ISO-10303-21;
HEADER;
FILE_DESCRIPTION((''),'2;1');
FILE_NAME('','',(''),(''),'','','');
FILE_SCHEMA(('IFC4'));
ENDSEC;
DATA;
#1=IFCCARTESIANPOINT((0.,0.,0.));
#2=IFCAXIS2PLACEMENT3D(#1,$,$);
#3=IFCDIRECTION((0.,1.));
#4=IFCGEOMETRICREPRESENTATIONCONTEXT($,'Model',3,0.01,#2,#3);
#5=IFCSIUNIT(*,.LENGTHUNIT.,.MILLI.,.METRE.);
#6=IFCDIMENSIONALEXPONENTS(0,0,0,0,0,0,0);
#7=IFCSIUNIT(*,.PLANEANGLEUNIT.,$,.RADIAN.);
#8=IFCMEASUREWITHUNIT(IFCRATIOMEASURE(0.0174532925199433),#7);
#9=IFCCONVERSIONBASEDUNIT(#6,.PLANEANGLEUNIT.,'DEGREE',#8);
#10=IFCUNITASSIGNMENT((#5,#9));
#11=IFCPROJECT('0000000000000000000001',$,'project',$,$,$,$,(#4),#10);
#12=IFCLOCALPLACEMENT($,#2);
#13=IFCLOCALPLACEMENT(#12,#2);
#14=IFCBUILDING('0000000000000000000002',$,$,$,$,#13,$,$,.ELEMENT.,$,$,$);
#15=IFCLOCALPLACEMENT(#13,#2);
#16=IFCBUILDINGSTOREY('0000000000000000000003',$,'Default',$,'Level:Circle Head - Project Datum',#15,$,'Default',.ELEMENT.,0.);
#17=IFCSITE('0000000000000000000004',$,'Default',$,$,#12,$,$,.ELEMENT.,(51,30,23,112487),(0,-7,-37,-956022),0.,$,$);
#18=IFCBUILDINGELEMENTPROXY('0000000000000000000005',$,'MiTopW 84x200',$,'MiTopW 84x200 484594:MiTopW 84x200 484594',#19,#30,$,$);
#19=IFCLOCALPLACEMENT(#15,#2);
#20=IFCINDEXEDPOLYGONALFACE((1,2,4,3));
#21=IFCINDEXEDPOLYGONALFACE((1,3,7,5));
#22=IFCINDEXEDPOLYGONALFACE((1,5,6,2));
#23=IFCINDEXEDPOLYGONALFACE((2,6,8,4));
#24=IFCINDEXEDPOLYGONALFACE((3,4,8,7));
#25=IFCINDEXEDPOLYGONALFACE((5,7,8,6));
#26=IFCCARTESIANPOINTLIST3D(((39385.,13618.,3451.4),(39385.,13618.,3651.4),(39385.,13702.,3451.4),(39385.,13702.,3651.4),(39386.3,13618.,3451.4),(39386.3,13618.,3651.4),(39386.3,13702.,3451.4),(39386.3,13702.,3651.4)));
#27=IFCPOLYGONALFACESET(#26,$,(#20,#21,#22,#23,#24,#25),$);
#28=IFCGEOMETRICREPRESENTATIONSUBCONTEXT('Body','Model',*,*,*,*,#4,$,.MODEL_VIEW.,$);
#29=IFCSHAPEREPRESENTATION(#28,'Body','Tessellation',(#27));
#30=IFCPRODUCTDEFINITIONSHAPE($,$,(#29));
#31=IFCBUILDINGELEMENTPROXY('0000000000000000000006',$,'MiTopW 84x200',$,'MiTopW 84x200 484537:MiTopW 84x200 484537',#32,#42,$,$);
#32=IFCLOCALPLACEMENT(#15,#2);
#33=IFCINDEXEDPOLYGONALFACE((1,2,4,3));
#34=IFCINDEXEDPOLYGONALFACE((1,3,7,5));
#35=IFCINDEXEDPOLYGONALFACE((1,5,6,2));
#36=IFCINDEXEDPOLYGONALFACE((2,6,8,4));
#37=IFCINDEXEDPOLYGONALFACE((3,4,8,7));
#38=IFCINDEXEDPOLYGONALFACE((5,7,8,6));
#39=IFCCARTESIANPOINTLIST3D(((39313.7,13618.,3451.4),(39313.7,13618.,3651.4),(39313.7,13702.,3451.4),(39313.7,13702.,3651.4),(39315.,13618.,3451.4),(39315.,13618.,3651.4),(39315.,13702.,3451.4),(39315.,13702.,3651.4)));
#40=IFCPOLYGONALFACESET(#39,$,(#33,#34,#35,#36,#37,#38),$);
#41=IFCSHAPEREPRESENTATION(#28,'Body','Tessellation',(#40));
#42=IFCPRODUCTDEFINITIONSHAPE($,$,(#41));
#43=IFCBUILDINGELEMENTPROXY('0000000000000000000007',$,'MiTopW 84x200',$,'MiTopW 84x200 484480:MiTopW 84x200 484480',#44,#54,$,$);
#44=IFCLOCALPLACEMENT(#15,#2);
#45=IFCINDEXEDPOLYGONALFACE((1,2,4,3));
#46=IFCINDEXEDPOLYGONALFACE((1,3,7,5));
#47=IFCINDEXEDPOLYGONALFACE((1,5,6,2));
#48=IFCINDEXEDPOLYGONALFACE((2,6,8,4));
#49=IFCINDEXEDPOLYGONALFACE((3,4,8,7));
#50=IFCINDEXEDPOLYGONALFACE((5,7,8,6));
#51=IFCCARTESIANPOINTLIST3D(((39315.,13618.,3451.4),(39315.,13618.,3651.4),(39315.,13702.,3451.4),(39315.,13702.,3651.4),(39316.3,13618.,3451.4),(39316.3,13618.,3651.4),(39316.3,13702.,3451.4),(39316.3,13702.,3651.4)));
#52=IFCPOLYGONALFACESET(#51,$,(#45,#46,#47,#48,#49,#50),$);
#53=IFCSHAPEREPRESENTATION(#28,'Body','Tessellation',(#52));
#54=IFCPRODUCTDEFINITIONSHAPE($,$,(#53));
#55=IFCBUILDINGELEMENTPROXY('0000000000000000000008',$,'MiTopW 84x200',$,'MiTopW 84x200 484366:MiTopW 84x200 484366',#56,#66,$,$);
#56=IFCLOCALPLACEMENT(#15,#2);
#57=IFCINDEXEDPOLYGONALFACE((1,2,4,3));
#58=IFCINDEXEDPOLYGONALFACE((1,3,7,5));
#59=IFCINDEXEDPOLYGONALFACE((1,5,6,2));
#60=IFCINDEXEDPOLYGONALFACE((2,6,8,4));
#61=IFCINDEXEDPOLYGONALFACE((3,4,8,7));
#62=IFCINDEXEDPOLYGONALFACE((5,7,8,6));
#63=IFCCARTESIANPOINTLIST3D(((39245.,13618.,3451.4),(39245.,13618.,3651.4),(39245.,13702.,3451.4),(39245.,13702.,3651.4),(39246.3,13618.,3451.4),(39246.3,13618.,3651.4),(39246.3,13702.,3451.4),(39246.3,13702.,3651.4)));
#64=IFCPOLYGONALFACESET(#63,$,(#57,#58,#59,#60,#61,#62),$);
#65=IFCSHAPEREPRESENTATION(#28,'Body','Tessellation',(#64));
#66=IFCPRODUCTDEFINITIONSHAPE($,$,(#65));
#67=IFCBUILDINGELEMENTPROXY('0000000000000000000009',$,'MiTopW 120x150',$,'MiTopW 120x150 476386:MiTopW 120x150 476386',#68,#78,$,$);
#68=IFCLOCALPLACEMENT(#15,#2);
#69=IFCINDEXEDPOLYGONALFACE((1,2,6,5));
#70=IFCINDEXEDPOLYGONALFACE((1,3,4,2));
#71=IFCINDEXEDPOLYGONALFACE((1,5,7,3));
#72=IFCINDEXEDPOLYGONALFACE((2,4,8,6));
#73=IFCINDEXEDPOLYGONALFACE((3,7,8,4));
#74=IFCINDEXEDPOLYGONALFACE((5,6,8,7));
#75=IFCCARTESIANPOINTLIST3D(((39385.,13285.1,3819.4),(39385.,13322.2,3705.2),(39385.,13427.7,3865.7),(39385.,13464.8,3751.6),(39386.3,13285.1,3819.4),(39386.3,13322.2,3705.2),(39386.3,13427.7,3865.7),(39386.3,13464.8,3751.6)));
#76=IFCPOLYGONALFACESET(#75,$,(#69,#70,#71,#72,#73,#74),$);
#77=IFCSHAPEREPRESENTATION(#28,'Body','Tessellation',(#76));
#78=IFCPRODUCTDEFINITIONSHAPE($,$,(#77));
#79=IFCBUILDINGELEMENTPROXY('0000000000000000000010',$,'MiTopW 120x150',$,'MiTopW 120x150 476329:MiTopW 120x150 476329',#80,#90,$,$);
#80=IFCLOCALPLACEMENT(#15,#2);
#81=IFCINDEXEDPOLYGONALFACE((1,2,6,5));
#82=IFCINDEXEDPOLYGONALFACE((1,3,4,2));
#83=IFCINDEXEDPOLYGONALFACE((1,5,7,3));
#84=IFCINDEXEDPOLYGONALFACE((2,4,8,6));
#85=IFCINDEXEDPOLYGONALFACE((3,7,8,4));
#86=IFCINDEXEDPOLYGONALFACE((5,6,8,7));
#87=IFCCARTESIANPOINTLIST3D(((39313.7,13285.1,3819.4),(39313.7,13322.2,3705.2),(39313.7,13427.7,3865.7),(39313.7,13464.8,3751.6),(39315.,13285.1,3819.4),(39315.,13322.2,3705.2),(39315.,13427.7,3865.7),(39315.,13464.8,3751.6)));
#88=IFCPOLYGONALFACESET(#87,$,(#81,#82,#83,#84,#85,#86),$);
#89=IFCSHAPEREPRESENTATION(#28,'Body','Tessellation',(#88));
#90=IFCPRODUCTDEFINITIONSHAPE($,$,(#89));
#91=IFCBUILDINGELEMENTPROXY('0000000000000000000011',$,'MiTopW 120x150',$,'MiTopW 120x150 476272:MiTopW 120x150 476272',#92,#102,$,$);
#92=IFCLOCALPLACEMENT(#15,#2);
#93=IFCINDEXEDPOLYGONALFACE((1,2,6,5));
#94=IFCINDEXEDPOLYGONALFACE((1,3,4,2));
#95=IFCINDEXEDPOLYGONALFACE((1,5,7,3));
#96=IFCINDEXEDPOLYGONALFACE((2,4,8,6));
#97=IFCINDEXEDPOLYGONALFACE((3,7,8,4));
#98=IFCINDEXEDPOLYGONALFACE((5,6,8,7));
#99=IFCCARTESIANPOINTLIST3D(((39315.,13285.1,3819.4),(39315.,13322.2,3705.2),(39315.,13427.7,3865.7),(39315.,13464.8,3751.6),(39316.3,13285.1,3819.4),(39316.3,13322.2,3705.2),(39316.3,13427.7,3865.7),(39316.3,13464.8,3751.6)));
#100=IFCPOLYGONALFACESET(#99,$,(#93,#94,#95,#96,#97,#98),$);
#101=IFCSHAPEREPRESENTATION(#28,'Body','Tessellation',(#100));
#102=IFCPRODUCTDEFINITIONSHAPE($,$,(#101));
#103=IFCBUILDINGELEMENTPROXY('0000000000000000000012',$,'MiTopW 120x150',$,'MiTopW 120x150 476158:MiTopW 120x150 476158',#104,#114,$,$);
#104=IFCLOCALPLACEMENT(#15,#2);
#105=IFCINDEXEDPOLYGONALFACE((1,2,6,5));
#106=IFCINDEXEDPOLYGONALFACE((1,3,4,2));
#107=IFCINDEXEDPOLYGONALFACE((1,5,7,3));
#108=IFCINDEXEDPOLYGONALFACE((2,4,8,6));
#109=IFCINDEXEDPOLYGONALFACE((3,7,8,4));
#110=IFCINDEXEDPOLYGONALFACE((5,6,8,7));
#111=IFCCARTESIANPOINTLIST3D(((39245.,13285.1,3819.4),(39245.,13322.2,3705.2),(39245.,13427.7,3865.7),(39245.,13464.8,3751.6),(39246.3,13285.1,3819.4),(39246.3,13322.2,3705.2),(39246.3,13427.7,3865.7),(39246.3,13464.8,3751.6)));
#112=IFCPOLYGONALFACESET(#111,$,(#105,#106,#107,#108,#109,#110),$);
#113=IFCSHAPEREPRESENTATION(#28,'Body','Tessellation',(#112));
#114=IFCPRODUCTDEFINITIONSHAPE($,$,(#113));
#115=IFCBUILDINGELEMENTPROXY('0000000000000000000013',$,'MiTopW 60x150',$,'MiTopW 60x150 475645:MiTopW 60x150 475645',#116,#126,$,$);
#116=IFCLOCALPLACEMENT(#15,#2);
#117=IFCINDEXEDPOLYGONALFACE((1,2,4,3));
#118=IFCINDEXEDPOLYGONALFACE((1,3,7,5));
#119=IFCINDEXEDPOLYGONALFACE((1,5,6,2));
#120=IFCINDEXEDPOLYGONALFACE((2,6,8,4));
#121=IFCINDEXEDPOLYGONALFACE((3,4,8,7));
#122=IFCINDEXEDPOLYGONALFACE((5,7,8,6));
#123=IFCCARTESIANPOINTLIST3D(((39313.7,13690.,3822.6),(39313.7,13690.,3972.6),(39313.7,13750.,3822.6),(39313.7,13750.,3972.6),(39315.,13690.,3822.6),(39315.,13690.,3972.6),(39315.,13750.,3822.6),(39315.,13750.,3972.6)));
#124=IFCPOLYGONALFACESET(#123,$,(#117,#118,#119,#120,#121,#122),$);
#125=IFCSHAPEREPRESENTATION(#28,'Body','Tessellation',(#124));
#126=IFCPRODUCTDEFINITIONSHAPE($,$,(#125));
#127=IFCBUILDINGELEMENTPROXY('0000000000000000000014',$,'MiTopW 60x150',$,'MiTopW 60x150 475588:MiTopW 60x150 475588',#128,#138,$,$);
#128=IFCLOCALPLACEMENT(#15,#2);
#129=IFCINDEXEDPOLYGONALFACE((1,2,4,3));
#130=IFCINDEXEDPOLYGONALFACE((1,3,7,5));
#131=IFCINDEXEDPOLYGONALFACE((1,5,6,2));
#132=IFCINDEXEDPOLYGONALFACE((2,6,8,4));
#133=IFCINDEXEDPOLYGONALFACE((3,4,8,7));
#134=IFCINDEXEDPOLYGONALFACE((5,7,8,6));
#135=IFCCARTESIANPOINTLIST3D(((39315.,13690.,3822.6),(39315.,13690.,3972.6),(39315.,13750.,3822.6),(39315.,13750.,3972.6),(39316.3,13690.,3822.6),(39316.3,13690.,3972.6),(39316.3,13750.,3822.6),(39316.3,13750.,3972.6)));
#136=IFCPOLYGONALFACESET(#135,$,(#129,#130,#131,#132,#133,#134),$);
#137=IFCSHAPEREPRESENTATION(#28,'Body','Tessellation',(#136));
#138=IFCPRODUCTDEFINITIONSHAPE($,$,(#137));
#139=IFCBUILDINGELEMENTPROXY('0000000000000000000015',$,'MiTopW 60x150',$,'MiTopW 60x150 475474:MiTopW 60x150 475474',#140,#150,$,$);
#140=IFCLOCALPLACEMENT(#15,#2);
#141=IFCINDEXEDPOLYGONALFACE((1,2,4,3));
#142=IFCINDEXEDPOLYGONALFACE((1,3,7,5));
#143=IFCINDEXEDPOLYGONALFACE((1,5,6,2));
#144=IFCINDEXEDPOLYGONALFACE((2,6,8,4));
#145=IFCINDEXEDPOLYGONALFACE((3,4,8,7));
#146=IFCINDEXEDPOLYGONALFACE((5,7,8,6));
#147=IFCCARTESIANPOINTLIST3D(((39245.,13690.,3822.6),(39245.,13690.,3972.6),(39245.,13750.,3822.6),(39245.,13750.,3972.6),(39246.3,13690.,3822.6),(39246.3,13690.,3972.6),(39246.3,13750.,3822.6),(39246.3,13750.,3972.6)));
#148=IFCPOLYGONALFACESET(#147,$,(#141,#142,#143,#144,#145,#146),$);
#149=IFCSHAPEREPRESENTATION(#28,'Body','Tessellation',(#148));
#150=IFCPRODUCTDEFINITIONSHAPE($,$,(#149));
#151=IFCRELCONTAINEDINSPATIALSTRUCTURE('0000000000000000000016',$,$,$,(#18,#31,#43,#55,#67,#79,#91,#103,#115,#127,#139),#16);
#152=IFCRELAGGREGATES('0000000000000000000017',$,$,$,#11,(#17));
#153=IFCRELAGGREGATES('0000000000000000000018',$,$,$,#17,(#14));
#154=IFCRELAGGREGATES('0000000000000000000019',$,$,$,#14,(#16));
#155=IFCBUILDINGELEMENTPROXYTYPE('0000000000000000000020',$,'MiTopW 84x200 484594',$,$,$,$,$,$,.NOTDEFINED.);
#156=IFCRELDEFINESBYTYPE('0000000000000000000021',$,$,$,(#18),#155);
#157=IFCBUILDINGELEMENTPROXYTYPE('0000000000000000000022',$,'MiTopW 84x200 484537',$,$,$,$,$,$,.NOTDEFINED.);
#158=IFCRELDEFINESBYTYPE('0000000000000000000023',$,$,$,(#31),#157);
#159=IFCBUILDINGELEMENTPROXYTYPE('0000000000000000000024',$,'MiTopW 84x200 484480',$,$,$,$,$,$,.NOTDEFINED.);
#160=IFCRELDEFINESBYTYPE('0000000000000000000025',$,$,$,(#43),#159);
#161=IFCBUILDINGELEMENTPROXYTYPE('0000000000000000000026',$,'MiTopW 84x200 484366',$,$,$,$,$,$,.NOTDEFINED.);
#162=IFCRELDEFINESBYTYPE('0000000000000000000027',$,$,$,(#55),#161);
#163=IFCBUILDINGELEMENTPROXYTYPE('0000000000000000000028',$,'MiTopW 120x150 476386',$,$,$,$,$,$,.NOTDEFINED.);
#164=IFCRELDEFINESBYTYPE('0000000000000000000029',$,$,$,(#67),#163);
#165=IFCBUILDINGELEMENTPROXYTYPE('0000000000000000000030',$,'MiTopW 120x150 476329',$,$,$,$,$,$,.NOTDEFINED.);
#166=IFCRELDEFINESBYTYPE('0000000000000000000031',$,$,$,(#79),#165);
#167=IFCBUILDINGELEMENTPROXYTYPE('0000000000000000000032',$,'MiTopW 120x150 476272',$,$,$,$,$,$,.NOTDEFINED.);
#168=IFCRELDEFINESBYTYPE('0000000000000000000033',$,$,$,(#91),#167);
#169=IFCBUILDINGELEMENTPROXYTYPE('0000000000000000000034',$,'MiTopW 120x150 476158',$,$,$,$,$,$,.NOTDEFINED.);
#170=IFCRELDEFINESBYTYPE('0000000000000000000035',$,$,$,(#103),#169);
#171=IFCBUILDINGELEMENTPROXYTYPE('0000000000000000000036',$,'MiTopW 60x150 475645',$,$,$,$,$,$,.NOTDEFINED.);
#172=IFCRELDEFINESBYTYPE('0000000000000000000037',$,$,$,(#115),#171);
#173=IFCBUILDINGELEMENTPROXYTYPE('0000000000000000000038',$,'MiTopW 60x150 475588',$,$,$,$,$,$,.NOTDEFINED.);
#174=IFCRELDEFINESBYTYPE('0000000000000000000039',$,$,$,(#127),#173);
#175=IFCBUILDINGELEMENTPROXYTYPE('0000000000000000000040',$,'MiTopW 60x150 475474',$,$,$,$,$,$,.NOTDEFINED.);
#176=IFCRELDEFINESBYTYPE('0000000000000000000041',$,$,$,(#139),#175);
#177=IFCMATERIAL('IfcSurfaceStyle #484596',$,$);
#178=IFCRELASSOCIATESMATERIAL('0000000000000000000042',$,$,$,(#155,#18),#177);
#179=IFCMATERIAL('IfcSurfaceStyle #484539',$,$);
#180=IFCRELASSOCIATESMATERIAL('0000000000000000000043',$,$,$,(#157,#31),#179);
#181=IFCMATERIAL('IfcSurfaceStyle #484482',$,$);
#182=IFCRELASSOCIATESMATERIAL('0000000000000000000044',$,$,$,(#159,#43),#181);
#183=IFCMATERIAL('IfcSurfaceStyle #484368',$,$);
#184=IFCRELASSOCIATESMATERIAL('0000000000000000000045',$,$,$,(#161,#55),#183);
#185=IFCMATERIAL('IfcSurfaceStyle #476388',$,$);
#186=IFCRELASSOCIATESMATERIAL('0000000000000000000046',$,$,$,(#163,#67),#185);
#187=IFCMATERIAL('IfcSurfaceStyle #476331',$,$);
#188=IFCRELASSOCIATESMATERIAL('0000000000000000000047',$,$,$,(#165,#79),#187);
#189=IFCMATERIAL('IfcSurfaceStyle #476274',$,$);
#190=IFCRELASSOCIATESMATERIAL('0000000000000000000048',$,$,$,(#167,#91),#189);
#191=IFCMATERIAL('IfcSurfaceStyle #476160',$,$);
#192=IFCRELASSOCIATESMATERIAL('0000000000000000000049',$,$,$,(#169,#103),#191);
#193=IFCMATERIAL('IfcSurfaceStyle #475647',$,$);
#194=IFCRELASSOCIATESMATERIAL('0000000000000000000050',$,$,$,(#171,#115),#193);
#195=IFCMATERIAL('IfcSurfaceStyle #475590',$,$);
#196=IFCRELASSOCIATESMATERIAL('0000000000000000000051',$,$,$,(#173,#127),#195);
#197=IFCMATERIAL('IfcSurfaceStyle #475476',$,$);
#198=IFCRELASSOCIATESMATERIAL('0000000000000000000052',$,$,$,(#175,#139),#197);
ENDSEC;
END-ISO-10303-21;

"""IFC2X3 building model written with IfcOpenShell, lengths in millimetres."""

from ifc_helpers import new_model, entity, si_unit, converted_unit, direction, frame, frame_2d, origin, origin_2d_with_axis, place, context, subcontext, project, spatial, polyline, rectangle, outline, extrude, source, transform, mapped, material, type_object, type_shapes, element, save


model = new_model("IFC2X3")

# Units and contexts
model_context = context("Model", 3, precision=0.01, world=origin(), true_north=direction((0.0, 1.0)))
body_context = subcontext(model_context, "Body", "Model", "MODEL_VIEW")
ifc_project = project(units=[si_unit("LENGTHUNIT", "METRE", prefix="MILLI"), converted_unit("PLANEANGLEUNIT", "DEGREE", entity("IfcRatioMeasure", 0.0174532925199433), si_unit("PLANEANGLEUNIT", "RADIAN"), dimensions=[0, 0, 0, 0, 0, 0, 0])], contexts=[model_context])

# Site, building, storey
site_placement = place(None, origin())
site = spatial("IfcSite", under=ifc_project, at=site_placement, Name="Default", CompositionType="ELEMENT", RefLatitude=(51, 30, 23, 112487), RefLongitude=(0, -7, -37, -956022), RefElevation=0.0)
building_placement = place(site_placement, origin())
building = spatial("IfcBuilding", under=site, at=building_placement, CompositionType="ELEMENT")
storey_placement = place(building_placement, origin())
storey = spatial("IfcBuildingStorey", under=building, at=storey_placement, Name="Default", ObjectType="Level:Circle Head - Project Datum", LongName="Default", CompositionType="ELEMENT", Elevation=0.0)

# Building element proxies
ifc_material_1 = material(Name="IfcSurfaceStyle #484596")
building_element_proxy_type_1 = type_object("IfcBuildingElementProxyType", Name="MiTopW 84x200 484594", PredefinedType="NOTDEFINED", material=ifc_material_1)
shared_shape_1 = source(origin(), body_context, "Body", "SweptSolid", [
    extrude(rectangle(XDim=200.0, YDim=84.0, at=frame_2d((0.0, 0.0), x_axis=(1.0, 0.0))), frame((100.0, 42.0, 0.0), z_axis=(0.0, 0.0, 1.0), x_axis=(-1.0, 0.0, 0.0)), (0.0, 0.0, 1.0), 1.3),
])
type_shapes(building_element_proxy_type_1, [shared_shape_1])
proxy_1_placement = place(building_placement, frame((39386.3, 13702.0, 3651.4), z_axis=(-1.0, 0.0, 0.0), x_axis=(0.0, 0.0, -1.0)))
element("IfcBuildingElementProxy", 1, at=proxy_1_placement, inside=storey, type_object=building_element_proxy_type_1, material=ifc_material_1, Name="MiTopW 84x200", ObjectType="MiTopW 84x200 484594:MiTopW 84x200 484594", context=body_context, shape_type="MappedRepresentation", body=[
    mapped(shared_shape_1, transform((0.0, 0.0, 0.0), scale=1.0)),
])
ifc_material_2 = material(Name="IfcSurfaceStyle #484539")
building_element_proxy_type_2 = type_object("IfcBuildingElementProxyType", Name="MiTopW 84x200 484537", PredefinedType="NOTDEFINED", material=ifc_material_2)
shared_shape_2 = source(origin(), body_context, "Body", "SweptSolid", [
    extrude(rectangle(XDim=200.0, YDim=84.0, at=frame_2d((0.0, 0.0), x_axis=(1.0, 0.0))), frame((100.0, 42.0, 0.0), z_axis=(0.0, 0.0, 1.0), x_axis=(-1.0, 0.0, 0.0)), (0.0, 0.0, 1.0), 1.3),
])
type_shapes(building_element_proxy_type_2, [shared_shape_2])
proxy_2_placement = place(building_placement, frame((39315.0, 13702.0, 3651.4), z_axis=(-1.0, 0.0, 0.0), x_axis=(0.0, 0.0, -1.0)))
element("IfcBuildingElementProxy", 2, at=proxy_2_placement, inside=storey, type_object=building_element_proxy_type_2, material=ifc_material_2, Name="MiTopW 84x200", ObjectType="MiTopW 84x200 484537:MiTopW 84x200 484537", context=body_context, shape_type="MappedRepresentation", body=[
    mapped(shared_shape_2, transform((0.0, 0.0, 0.0), scale=1.0)),
])
ifc_material_3 = material(Name="IfcSurfaceStyle #484482")
building_element_proxy_type_3 = type_object("IfcBuildingElementProxyType", Name="MiTopW 84x200 484480", PredefinedType="NOTDEFINED", material=ifc_material_3)
shared_shape_3 = source(origin(), body_context, "Body", "SweptSolid", [
    extrude(rectangle(XDim=200.0, YDim=84.0, at=frame_2d((0.0, 0.0), x_axis=(1.0, 0.0))), frame((100.0, 42.0, 0.0), z_axis=(0.0, 0.0, 1.0), x_axis=(-1.0, 0.0, 0.0)), (0.0, 0.0, 1.0), 1.3),
])
type_shapes(building_element_proxy_type_3, [shared_shape_3])
proxy_3_placement = place(building_placement, frame((39316.3, 13702.0, 3651.4), z_axis=(-1.0, 0.0, 0.0), x_axis=(0.0, 0.0, -1.0)))
element("IfcBuildingElementProxy", 3, at=proxy_3_placement, inside=storey, type_object=building_element_proxy_type_3, material=ifc_material_3, Name="MiTopW 84x200", ObjectType="MiTopW 84x200 484480:MiTopW 84x200 484480", context=body_context, shape_type="MappedRepresentation", body=[
    mapped(shared_shape_3, transform((0.0, 0.0, 0.0), scale=1.0)),
])
ifc_material_4 = material(Name="IfcSurfaceStyle #484368")
building_element_proxy_type_4 = type_object("IfcBuildingElementProxyType", Name="MiTopW 84x200 484366", PredefinedType="NOTDEFINED", material=ifc_material_4)
shared_shape_4 = source(origin(), body_context, "Body", "SweptSolid", [
    extrude(rectangle(XDim=200.0, YDim=84.0, at=frame_2d((0.0, 0.0), x_axis=(1.0, 0.0))), frame((100.0, 42.0, 0.0), z_axis=(0.0, 0.0, 1.0), x_axis=(-1.0, 0.0, 0.0)), (0.0, 0.0, 1.0), 1.3),
])
type_shapes(building_element_proxy_type_4, [shared_shape_4])
proxy_4_placement = place(building_placement, frame((39246.3, 13702.0, 3651.4), z_axis=(-1.0, 0.0, 0.0), x_axis=(0.0, 0.0, -1.0)))
element("IfcBuildingElementProxy", 4, at=proxy_4_placement, inside=storey, type_object=building_element_proxy_type_4, material=ifc_material_4, Name="MiTopW 84x200", ObjectType="MiTopW 84x200 484366:MiTopW 84x200 484366", context=body_context, shape_type="MappedRepresentation", body=[
    mapped(shared_shape_4, transform((0.0, 0.0, 0.0), scale=1.0)),
])
ifc_material_5 = material(Name="IfcSurfaceStyle #476388")
building_element_proxy_type_5 = type_object("IfcBuildingElementProxyType", Name="MiTopW 120x150 476386", PredefinedType="NOTDEFINED", material=ifc_material_5)
shared_shape_5 = source(origin(), body_context, "Body", "SweptSolid", [
    extrude(outline(polyline([(-75.0, -60.0), (75.0, -60.0), (75.0, 60.0), (-75.0, 60.0), (-75.0, -60.0)])), frame((75.0, 60.0, 0.0), z_axis=(0.0, 0.0, 1.0), x_axis=(-1.0, 0.0, 0.0)), (0.0, 0.0, 1.0), 1.3),
])
type_shapes(building_element_proxy_type_5, [shared_shape_5])
proxy_5_placement = place(building_placement, frame((39386.3, 13285.1, 3819.4), z_axis=(-1.0, 0.0, 0.0), x_axis=(0.0, 0.951057, 0.309017)))
element("IfcBuildingElementProxy", 5, at=proxy_5_placement, inside=storey, type_object=building_element_proxy_type_5, material=ifc_material_5, Name="MiTopW 120x150", ObjectType="MiTopW 120x150 476386:MiTopW 120x150 476386", context=body_context, shape_type="MappedRepresentation", body=[
    mapped(shared_shape_5, transform((0.0, 0.0, 0.0), scale=1.0)),
])
ifc_material_6 = material(Name="IfcSurfaceStyle #476331")
building_element_proxy_type_6 = type_object("IfcBuildingElementProxyType", Name="MiTopW 120x150 476329", PredefinedType="NOTDEFINED", material=ifc_material_6)
shared_shape_6 = source(origin(), body_context, "Body", "SweptSolid", [
    extrude(outline(polyline([(-75.0, -60.0), (75.0, -60.0), (75.0, 60.0), (-75.0, 60.0), (-75.0, -60.0)])), frame((75.0, 60.0, 0.0), z_axis=(0.0, 0.0, 1.0), x_axis=(-1.0, 0.0, 0.0)), (0.0, 0.0, 1.0), 1.3),
])
type_shapes(building_element_proxy_type_6, [shared_shape_6])
proxy_6_placement = place(building_placement, frame((39315.0, 13285.1, 3819.4), z_axis=(-1.0, 0.0, 0.0), x_axis=(0.0, 0.951057, 0.309017)))
element("IfcBuildingElementProxy", 6, at=proxy_6_placement, inside=storey, type_object=building_element_proxy_type_6, material=ifc_material_6, Name="MiTopW 120x150", ObjectType="MiTopW 120x150 476329:MiTopW 120x150 476329", context=body_context, shape_type="MappedRepresentation", body=[
    mapped(shared_shape_6, transform((0.0, 0.0, 0.0), scale=1.0)),
])
ifc_material_7 = material(Name="IfcSurfaceStyle #476274")
building_element_proxy_type_7 = type_object("IfcBuildingElementProxyType", Name="MiTopW 120x150 476272", PredefinedType="NOTDEFINED", material=ifc_material_7)
shared_shape_7 = source(origin(), body_context, "Body", "SweptSolid", [
    extrude(outline(polyline([(-75.0, -60.0), (75.0, -60.0), (75.0, 60.0), (-75.0, 60.0), (-75.0, -60.0)])), frame((75.0, 60.0, 0.0), z_axis=(0.0, 0.0, 1.0), x_axis=(-1.0, 0.0, 0.0)), (0.0, 0.0, 1.0), 1.3),
])
type_shapes(building_element_proxy_type_7, [shared_shape_7])
proxy_7_placement = place(building_placement, frame((39316.3, 13285.1, 3819.4), z_axis=(-1.0, 0.0, 0.0), x_axis=(0.0, 0.951057, 0.309017)))
element("IfcBuildingElementProxy", 7, at=proxy_7_placement, inside=storey, type_object=building_element_proxy_type_7, material=ifc_material_7, Name="MiTopW 120x150", ObjectType="MiTopW 120x150 476272:MiTopW 120x150 476272", context=body_context, shape_type="MappedRepresentation", body=[
    mapped(shared_shape_7, transform((0.0, 0.0, 0.0), scale=1.0)),
])
ifc_material_8 = material(Name="IfcSurfaceStyle #476160")
building_element_proxy_type_8 = type_object("IfcBuildingElementProxyType", Name="MiTopW 120x150 476158", PredefinedType="NOTDEFINED", material=ifc_material_8)
shared_shape_8 = source(origin(), body_context, "Body", "SweptSolid", [
    extrude(outline(polyline([(-75.0, -60.0), (75.0, -60.0), (75.0, 60.0), (-75.0, 60.0), (-75.0, -60.0)])), frame((75.0, 60.0, 0.0), z_axis=(0.0, 0.0, 1.0), x_axis=(-1.0, 0.0, 0.0)), (0.0, 0.0, 1.0), 1.3),
])
type_shapes(building_element_proxy_type_8, [shared_shape_8])
proxy_8_placement = place(building_placement, frame((39246.3, 13285.1, 3819.4), z_axis=(-1.0, 0.0, 0.0), x_axis=(0.0, 0.951057, 0.309017)))
element("IfcBuildingElementProxy", 8, at=proxy_8_placement, inside=storey, type_object=building_element_proxy_type_8, material=ifc_material_8, Name="MiTopW 120x150", ObjectType="MiTopW 120x150 476158:MiTopW 120x150 476158", context=body_context, shape_type="MappedRepresentation", body=[
    mapped(shared_shape_8, transform((0.0, 0.0, 0.0), scale=1.0)),
])
ifc_material_9 = material(Name="IfcSurfaceStyle #475647")
building_element_proxy_type_9 = type_object("IfcBuildingElementProxyType", Name="MiTopW 60x150 475645", PredefinedType="NOTDEFINED", material=ifc_material_9)
shared_shape_9 = source(origin(), body_context, "Body", "SweptSolid", [
    extrude(rectangle(XDim=150.0, YDim=60.0, at=origin_2d_with_axis()), frame((75.0, 30.0, 0.0), z_axis=(0.0, 0.0, 1.0), x_axis=(-1.0, 0.0, 0.0)), (0.0, 0.0, 1.0), 1.3),
])
type_shapes(building_element_proxy_type_9, [shared_shape_9])
proxy_9_placement = place(building_placement, frame((39315.0, 13750.0, 3972.6), z_axis=(-1.0, 0.0, 0.0), x_axis=(0.0, 0.0, -1.0)))
element("IfcBuildingElementProxy", 9, at=proxy_9_placement, inside=storey, type_object=building_element_proxy_type_9, material=ifc_material_9, Name="MiTopW 60x150", ObjectType="MiTopW 60x150 475645:MiTopW 60x150 475645", context=body_context, shape_type="MappedRepresentation", body=[
    mapped(shared_shape_9, transform((0.0, 0.0, 0.0), scale=1.0)),
])
ifc_material_10 = material(Name="IfcSurfaceStyle #475590")
building_element_proxy_type_10 = type_object("IfcBuildingElementProxyType", Name="MiTopW 60x150 475588", PredefinedType="NOTDEFINED", material=ifc_material_10)
shared_shape_10 = source(origin(), body_context, "Body", "SweptSolid", [
    extrude(rectangle(XDim=150.0, YDim=60.0, at=origin_2d_with_axis()), frame((75.0, 30.0, 0.0), z_axis=(0.0, 0.0, 1.0), x_axis=(-1.0, 0.0, 0.0)), (0.0, 0.0, 1.0), 1.3),
])
type_shapes(building_element_proxy_type_10, [shared_shape_10])
proxy_10_placement = place(building_placement, frame((39316.3, 13750.0, 3972.6), z_axis=(-1.0, 0.0, 0.0), x_axis=(0.0, 0.0, -1.0)))
element("IfcBuildingElementProxy", 10, at=proxy_10_placement, inside=storey, type_object=building_element_proxy_type_10, material=ifc_material_10, Name="MiTopW 60x150", ObjectType="MiTopW 60x150 475588:MiTopW 60x150 475588", context=body_context, shape_type="MappedRepresentation", body=[
    mapped(shared_shape_10, transform((0.0, 0.0, 0.0), scale=1.0)),
])
ifc_material_11 = material(Name="IfcSurfaceStyle #475476")
building_element_proxy_type_11 = type_object("IfcBuildingElementProxyType", Name="MiTopW 60x150 475474", PredefinedType="NOTDEFINED", material=ifc_material_11)
shared_shape_11 = source(origin(), body_context, "Body", "SweptSolid", [
    extrude(rectangle(XDim=150.0, YDim=60.0, at=origin_2d_with_axis()), frame((75.0, 30.0, 0.0), z_axis=(0.0, 0.0, 1.0), x_axis=(-1.0, 0.0, 0.0)), (0.0, 0.0, 1.0), 1.3),
])
type_shapes(building_element_proxy_type_11, [shared_shape_11])
proxy_11_placement = place(building_placement, frame((39246.3, 13750.0, 3972.6), z_axis=(-1.0, 0.0, 0.0), x_axis=(0.0, 0.0, -1.0)))
element("IfcBuildingElementProxy", 11, at=proxy_11_placement, inside=storey, type_object=building_element_proxy_type_11, material=ifc_material_11, Name="MiTopW 60x150", ObjectType="MiTopW 60x150 475474:MiTopW 60x150 475474", context=body_context, shape_type="MappedRepresentation", body=[
    mapped(shared_shape_11, transform((0.0, 0.0, 0.0), scale=1.0)),
])

save(model, "model.ifc")
